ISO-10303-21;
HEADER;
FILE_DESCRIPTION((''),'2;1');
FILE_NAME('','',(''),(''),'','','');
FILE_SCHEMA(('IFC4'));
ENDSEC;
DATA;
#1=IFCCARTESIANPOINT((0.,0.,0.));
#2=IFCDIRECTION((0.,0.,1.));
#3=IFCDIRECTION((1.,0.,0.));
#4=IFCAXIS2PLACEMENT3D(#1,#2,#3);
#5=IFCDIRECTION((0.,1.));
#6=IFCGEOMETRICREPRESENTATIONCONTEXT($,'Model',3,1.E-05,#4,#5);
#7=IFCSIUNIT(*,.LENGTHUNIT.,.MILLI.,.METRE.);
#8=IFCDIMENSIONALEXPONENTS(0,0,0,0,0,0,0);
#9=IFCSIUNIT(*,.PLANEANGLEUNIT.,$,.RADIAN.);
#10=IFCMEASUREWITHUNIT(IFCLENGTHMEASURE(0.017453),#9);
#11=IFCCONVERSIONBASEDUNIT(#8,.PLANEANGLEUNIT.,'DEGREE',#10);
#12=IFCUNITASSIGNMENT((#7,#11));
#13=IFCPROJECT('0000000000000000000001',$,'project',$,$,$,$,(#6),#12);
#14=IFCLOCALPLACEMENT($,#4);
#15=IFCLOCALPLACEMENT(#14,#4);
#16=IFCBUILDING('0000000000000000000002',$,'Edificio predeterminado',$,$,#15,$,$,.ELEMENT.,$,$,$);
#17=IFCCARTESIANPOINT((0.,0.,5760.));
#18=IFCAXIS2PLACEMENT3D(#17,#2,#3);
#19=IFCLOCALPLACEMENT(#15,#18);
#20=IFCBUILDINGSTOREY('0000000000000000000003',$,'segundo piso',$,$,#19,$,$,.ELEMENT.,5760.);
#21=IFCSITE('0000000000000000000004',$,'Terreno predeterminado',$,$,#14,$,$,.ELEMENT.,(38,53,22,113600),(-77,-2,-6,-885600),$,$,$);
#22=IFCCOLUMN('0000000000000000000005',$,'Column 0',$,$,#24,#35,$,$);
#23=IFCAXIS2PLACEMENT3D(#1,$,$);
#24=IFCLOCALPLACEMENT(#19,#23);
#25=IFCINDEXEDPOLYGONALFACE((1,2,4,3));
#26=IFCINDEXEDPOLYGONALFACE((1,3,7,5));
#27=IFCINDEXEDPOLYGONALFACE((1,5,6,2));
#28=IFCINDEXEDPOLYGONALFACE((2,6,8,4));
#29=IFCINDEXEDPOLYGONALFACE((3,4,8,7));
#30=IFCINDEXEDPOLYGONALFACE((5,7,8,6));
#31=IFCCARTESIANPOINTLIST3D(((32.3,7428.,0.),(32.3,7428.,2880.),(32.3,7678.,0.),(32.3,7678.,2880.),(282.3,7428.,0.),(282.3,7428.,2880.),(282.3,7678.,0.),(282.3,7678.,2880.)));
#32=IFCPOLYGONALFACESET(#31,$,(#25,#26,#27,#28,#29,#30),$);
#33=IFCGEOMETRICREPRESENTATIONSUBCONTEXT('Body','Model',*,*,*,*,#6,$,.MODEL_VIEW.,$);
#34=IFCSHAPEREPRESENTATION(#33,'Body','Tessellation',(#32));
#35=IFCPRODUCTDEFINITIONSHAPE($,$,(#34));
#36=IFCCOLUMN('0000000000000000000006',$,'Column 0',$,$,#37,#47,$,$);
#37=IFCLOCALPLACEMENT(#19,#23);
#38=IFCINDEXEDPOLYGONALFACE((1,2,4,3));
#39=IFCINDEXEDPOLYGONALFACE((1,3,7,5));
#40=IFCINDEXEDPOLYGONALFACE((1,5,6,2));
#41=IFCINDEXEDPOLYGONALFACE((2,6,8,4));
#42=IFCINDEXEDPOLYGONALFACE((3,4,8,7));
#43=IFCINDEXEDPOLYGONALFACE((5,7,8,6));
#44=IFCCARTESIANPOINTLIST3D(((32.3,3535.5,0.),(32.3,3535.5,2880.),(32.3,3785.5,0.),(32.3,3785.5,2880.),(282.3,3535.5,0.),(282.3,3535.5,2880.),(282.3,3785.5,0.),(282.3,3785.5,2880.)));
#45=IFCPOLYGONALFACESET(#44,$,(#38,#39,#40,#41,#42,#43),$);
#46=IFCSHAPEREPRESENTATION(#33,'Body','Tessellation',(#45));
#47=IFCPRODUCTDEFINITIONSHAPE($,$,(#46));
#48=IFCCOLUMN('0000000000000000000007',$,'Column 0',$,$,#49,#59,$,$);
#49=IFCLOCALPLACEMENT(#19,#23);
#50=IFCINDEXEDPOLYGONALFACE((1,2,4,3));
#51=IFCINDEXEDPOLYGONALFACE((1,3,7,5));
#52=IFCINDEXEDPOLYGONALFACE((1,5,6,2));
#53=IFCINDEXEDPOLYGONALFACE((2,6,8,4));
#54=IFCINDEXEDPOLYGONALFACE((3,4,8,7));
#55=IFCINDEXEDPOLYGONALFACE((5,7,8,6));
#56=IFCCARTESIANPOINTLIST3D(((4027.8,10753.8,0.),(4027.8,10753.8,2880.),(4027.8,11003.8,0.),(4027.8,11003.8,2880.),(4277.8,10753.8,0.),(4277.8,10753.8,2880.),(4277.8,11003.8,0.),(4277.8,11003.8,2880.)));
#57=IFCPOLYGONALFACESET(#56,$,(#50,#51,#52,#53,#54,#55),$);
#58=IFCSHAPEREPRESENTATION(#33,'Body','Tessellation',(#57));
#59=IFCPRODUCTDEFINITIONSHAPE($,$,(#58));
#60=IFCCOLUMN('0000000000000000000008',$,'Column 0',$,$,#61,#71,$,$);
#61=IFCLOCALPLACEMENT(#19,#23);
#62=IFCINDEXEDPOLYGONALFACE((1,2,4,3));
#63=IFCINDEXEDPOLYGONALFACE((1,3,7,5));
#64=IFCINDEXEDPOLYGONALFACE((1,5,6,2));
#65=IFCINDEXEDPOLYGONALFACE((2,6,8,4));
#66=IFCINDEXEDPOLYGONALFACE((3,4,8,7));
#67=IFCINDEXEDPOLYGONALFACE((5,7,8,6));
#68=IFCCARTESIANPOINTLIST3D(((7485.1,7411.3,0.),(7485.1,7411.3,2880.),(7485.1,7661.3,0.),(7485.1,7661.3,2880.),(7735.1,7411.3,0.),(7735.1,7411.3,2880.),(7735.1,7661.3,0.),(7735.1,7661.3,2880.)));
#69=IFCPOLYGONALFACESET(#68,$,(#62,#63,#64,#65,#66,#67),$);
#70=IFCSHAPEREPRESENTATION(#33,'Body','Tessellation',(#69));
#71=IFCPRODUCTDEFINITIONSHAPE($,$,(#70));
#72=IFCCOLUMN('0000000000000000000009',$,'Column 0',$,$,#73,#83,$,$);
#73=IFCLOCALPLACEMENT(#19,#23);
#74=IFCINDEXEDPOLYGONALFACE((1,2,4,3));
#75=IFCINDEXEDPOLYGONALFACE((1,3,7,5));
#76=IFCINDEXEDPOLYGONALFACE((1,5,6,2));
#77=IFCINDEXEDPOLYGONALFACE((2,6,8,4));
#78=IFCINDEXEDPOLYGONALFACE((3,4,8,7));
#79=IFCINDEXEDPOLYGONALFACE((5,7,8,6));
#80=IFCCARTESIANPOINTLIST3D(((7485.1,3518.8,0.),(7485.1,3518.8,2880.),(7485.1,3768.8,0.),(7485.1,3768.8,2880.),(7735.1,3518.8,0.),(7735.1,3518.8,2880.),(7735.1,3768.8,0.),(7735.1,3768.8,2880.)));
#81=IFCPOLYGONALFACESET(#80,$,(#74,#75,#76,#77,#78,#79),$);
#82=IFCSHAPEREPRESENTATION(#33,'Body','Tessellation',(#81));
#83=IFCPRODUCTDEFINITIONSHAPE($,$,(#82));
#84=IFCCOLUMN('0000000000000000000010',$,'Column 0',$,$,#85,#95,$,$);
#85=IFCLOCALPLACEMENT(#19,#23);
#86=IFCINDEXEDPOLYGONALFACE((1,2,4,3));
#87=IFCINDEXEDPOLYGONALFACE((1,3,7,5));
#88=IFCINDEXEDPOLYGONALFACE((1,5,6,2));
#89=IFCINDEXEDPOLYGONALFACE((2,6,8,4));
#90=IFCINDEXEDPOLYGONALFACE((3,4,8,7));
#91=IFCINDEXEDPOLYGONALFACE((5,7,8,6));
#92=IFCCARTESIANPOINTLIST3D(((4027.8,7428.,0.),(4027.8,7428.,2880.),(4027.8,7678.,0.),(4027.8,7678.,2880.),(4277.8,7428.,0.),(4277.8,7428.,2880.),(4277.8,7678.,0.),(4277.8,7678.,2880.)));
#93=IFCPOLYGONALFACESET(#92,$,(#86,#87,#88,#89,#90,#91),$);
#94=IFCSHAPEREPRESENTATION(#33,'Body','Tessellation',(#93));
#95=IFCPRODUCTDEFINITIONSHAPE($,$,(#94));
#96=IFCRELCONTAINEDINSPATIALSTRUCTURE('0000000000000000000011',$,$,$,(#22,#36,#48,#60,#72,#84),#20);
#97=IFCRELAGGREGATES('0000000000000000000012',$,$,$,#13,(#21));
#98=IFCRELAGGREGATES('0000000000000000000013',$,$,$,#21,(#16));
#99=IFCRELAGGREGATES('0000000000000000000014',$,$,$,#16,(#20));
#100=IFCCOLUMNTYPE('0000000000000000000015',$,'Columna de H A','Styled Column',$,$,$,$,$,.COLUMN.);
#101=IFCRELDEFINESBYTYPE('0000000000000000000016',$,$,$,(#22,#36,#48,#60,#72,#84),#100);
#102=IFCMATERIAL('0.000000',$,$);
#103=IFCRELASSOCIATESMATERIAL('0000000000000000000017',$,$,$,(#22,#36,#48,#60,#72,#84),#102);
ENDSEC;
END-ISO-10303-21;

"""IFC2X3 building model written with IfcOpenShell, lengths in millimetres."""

from ifc_helpers import new_model, entity, si_unit, converted_unit, direction, frame, origin_with_axes, place, context, subcontext, project, spatial, polyline, outline, extrude, material, type_object, element, save


model = new_model("IFC2X3")

# Units and contexts
model_context = context("Model", 3, precision=1e-05, world=origin_with_axes(), true_north=direction((0.0, 1.0)))
body_context = subcontext(model_context, "Body", "Model", "MODEL_VIEW")
ifc_project = project(units=[si_unit("LENGTHUNIT", "METRE", prefix="MILLI"), converted_unit("PLANEANGLEUNIT", "DEGREE", entity("IfcLengthMeasure", 0.017453), si_unit("PLANEANGLEUNIT", "RADIAN"), dimensions=[0, 0, 0, 0, 0, 0, 0])], contexts=[model_context])

# Site, building, storey
site_placement = place(None, origin_with_axes())
site = spatial("IfcSite", under=ifc_project, at=site_placement, Name="Terreno predeterminado", CompositionType="ELEMENT", RefLatitude=(38, 53, 22, 113600), RefLongitude=(-77, -2, -6, -885600))
building_placement = place(site_placement, origin_with_axes())
building = spatial("IfcBuilding", under=site, at=building_placement, Name="Edificio predeterminado", CompositionType="ELEMENT")
storey_placement = place(building_placement, frame((0.0, 0.0, 5760.0), z_axis=(0.0, 0.0, 1.0), x_axis=(1.0, 0.0, 0.0)))
storey = spatial("IfcBuildingStorey", under=building, at=storey_placement, Name="segundo piso", CompositionType="ELEMENT", Elevation=5760.0)

# Columns
ifc_material_1 = material(Name="0.000000")
column_type = type_object("IfcColumnType", Name="Columna de H A", Description="Styled Column", PredefinedType="COLUMN")
for number, where, z_axis, x_axis, name in (
    (1, (157.3, 7553.0, 0.0), (0.0, 0.0, 1.0), (1.0, 0.0, 0.0), "Column 0"),
    (2, (157.3, 3660.5, 0.0), (0.0, 0.0, 1.0), (1.0, 0.0, 0.0), "Column 0"),
    (3, (4152.8, 10878.8, 0.0), (0.0, 0.0, 1.0), (1.0, 0.0, 0.0), "Column 0"),
    (4, (7610.1, 7536.3, 0.0), (0.0, 0.0, 1.0), (1.0, 0.0, 0.0), "Column 0"),
    (5, (7610.1, 3643.8, 0.0), (0.0, 0.0, 1.0), (1.0, 0.0, 0.0), "Column 0"),
    (6, (4152.8, 7553.0, 0.0), (0.0, 0.0, 1.0), (1.0, 0.0, 0.0), "Column 0"),
):
    element("IfcColumn", number, at=place(storey_placement, frame(where, z_axis=z_axis, x_axis=x_axis)), inside=storey, type_object=column_type, material=ifc_material_1, Name=name, context=body_context, shape_type="SweptSolid", body=[
        extrude(outline(polyline([(-125.0, -125.0), (125.0, -125.0), (125.0, 125.0), (-125.0, 125.0), (-125.0, -125.0)])), origin_with_axes(), (0.0, 0.0, 1.0), 2880.0),
    ])

save(model, "model.ifc")
